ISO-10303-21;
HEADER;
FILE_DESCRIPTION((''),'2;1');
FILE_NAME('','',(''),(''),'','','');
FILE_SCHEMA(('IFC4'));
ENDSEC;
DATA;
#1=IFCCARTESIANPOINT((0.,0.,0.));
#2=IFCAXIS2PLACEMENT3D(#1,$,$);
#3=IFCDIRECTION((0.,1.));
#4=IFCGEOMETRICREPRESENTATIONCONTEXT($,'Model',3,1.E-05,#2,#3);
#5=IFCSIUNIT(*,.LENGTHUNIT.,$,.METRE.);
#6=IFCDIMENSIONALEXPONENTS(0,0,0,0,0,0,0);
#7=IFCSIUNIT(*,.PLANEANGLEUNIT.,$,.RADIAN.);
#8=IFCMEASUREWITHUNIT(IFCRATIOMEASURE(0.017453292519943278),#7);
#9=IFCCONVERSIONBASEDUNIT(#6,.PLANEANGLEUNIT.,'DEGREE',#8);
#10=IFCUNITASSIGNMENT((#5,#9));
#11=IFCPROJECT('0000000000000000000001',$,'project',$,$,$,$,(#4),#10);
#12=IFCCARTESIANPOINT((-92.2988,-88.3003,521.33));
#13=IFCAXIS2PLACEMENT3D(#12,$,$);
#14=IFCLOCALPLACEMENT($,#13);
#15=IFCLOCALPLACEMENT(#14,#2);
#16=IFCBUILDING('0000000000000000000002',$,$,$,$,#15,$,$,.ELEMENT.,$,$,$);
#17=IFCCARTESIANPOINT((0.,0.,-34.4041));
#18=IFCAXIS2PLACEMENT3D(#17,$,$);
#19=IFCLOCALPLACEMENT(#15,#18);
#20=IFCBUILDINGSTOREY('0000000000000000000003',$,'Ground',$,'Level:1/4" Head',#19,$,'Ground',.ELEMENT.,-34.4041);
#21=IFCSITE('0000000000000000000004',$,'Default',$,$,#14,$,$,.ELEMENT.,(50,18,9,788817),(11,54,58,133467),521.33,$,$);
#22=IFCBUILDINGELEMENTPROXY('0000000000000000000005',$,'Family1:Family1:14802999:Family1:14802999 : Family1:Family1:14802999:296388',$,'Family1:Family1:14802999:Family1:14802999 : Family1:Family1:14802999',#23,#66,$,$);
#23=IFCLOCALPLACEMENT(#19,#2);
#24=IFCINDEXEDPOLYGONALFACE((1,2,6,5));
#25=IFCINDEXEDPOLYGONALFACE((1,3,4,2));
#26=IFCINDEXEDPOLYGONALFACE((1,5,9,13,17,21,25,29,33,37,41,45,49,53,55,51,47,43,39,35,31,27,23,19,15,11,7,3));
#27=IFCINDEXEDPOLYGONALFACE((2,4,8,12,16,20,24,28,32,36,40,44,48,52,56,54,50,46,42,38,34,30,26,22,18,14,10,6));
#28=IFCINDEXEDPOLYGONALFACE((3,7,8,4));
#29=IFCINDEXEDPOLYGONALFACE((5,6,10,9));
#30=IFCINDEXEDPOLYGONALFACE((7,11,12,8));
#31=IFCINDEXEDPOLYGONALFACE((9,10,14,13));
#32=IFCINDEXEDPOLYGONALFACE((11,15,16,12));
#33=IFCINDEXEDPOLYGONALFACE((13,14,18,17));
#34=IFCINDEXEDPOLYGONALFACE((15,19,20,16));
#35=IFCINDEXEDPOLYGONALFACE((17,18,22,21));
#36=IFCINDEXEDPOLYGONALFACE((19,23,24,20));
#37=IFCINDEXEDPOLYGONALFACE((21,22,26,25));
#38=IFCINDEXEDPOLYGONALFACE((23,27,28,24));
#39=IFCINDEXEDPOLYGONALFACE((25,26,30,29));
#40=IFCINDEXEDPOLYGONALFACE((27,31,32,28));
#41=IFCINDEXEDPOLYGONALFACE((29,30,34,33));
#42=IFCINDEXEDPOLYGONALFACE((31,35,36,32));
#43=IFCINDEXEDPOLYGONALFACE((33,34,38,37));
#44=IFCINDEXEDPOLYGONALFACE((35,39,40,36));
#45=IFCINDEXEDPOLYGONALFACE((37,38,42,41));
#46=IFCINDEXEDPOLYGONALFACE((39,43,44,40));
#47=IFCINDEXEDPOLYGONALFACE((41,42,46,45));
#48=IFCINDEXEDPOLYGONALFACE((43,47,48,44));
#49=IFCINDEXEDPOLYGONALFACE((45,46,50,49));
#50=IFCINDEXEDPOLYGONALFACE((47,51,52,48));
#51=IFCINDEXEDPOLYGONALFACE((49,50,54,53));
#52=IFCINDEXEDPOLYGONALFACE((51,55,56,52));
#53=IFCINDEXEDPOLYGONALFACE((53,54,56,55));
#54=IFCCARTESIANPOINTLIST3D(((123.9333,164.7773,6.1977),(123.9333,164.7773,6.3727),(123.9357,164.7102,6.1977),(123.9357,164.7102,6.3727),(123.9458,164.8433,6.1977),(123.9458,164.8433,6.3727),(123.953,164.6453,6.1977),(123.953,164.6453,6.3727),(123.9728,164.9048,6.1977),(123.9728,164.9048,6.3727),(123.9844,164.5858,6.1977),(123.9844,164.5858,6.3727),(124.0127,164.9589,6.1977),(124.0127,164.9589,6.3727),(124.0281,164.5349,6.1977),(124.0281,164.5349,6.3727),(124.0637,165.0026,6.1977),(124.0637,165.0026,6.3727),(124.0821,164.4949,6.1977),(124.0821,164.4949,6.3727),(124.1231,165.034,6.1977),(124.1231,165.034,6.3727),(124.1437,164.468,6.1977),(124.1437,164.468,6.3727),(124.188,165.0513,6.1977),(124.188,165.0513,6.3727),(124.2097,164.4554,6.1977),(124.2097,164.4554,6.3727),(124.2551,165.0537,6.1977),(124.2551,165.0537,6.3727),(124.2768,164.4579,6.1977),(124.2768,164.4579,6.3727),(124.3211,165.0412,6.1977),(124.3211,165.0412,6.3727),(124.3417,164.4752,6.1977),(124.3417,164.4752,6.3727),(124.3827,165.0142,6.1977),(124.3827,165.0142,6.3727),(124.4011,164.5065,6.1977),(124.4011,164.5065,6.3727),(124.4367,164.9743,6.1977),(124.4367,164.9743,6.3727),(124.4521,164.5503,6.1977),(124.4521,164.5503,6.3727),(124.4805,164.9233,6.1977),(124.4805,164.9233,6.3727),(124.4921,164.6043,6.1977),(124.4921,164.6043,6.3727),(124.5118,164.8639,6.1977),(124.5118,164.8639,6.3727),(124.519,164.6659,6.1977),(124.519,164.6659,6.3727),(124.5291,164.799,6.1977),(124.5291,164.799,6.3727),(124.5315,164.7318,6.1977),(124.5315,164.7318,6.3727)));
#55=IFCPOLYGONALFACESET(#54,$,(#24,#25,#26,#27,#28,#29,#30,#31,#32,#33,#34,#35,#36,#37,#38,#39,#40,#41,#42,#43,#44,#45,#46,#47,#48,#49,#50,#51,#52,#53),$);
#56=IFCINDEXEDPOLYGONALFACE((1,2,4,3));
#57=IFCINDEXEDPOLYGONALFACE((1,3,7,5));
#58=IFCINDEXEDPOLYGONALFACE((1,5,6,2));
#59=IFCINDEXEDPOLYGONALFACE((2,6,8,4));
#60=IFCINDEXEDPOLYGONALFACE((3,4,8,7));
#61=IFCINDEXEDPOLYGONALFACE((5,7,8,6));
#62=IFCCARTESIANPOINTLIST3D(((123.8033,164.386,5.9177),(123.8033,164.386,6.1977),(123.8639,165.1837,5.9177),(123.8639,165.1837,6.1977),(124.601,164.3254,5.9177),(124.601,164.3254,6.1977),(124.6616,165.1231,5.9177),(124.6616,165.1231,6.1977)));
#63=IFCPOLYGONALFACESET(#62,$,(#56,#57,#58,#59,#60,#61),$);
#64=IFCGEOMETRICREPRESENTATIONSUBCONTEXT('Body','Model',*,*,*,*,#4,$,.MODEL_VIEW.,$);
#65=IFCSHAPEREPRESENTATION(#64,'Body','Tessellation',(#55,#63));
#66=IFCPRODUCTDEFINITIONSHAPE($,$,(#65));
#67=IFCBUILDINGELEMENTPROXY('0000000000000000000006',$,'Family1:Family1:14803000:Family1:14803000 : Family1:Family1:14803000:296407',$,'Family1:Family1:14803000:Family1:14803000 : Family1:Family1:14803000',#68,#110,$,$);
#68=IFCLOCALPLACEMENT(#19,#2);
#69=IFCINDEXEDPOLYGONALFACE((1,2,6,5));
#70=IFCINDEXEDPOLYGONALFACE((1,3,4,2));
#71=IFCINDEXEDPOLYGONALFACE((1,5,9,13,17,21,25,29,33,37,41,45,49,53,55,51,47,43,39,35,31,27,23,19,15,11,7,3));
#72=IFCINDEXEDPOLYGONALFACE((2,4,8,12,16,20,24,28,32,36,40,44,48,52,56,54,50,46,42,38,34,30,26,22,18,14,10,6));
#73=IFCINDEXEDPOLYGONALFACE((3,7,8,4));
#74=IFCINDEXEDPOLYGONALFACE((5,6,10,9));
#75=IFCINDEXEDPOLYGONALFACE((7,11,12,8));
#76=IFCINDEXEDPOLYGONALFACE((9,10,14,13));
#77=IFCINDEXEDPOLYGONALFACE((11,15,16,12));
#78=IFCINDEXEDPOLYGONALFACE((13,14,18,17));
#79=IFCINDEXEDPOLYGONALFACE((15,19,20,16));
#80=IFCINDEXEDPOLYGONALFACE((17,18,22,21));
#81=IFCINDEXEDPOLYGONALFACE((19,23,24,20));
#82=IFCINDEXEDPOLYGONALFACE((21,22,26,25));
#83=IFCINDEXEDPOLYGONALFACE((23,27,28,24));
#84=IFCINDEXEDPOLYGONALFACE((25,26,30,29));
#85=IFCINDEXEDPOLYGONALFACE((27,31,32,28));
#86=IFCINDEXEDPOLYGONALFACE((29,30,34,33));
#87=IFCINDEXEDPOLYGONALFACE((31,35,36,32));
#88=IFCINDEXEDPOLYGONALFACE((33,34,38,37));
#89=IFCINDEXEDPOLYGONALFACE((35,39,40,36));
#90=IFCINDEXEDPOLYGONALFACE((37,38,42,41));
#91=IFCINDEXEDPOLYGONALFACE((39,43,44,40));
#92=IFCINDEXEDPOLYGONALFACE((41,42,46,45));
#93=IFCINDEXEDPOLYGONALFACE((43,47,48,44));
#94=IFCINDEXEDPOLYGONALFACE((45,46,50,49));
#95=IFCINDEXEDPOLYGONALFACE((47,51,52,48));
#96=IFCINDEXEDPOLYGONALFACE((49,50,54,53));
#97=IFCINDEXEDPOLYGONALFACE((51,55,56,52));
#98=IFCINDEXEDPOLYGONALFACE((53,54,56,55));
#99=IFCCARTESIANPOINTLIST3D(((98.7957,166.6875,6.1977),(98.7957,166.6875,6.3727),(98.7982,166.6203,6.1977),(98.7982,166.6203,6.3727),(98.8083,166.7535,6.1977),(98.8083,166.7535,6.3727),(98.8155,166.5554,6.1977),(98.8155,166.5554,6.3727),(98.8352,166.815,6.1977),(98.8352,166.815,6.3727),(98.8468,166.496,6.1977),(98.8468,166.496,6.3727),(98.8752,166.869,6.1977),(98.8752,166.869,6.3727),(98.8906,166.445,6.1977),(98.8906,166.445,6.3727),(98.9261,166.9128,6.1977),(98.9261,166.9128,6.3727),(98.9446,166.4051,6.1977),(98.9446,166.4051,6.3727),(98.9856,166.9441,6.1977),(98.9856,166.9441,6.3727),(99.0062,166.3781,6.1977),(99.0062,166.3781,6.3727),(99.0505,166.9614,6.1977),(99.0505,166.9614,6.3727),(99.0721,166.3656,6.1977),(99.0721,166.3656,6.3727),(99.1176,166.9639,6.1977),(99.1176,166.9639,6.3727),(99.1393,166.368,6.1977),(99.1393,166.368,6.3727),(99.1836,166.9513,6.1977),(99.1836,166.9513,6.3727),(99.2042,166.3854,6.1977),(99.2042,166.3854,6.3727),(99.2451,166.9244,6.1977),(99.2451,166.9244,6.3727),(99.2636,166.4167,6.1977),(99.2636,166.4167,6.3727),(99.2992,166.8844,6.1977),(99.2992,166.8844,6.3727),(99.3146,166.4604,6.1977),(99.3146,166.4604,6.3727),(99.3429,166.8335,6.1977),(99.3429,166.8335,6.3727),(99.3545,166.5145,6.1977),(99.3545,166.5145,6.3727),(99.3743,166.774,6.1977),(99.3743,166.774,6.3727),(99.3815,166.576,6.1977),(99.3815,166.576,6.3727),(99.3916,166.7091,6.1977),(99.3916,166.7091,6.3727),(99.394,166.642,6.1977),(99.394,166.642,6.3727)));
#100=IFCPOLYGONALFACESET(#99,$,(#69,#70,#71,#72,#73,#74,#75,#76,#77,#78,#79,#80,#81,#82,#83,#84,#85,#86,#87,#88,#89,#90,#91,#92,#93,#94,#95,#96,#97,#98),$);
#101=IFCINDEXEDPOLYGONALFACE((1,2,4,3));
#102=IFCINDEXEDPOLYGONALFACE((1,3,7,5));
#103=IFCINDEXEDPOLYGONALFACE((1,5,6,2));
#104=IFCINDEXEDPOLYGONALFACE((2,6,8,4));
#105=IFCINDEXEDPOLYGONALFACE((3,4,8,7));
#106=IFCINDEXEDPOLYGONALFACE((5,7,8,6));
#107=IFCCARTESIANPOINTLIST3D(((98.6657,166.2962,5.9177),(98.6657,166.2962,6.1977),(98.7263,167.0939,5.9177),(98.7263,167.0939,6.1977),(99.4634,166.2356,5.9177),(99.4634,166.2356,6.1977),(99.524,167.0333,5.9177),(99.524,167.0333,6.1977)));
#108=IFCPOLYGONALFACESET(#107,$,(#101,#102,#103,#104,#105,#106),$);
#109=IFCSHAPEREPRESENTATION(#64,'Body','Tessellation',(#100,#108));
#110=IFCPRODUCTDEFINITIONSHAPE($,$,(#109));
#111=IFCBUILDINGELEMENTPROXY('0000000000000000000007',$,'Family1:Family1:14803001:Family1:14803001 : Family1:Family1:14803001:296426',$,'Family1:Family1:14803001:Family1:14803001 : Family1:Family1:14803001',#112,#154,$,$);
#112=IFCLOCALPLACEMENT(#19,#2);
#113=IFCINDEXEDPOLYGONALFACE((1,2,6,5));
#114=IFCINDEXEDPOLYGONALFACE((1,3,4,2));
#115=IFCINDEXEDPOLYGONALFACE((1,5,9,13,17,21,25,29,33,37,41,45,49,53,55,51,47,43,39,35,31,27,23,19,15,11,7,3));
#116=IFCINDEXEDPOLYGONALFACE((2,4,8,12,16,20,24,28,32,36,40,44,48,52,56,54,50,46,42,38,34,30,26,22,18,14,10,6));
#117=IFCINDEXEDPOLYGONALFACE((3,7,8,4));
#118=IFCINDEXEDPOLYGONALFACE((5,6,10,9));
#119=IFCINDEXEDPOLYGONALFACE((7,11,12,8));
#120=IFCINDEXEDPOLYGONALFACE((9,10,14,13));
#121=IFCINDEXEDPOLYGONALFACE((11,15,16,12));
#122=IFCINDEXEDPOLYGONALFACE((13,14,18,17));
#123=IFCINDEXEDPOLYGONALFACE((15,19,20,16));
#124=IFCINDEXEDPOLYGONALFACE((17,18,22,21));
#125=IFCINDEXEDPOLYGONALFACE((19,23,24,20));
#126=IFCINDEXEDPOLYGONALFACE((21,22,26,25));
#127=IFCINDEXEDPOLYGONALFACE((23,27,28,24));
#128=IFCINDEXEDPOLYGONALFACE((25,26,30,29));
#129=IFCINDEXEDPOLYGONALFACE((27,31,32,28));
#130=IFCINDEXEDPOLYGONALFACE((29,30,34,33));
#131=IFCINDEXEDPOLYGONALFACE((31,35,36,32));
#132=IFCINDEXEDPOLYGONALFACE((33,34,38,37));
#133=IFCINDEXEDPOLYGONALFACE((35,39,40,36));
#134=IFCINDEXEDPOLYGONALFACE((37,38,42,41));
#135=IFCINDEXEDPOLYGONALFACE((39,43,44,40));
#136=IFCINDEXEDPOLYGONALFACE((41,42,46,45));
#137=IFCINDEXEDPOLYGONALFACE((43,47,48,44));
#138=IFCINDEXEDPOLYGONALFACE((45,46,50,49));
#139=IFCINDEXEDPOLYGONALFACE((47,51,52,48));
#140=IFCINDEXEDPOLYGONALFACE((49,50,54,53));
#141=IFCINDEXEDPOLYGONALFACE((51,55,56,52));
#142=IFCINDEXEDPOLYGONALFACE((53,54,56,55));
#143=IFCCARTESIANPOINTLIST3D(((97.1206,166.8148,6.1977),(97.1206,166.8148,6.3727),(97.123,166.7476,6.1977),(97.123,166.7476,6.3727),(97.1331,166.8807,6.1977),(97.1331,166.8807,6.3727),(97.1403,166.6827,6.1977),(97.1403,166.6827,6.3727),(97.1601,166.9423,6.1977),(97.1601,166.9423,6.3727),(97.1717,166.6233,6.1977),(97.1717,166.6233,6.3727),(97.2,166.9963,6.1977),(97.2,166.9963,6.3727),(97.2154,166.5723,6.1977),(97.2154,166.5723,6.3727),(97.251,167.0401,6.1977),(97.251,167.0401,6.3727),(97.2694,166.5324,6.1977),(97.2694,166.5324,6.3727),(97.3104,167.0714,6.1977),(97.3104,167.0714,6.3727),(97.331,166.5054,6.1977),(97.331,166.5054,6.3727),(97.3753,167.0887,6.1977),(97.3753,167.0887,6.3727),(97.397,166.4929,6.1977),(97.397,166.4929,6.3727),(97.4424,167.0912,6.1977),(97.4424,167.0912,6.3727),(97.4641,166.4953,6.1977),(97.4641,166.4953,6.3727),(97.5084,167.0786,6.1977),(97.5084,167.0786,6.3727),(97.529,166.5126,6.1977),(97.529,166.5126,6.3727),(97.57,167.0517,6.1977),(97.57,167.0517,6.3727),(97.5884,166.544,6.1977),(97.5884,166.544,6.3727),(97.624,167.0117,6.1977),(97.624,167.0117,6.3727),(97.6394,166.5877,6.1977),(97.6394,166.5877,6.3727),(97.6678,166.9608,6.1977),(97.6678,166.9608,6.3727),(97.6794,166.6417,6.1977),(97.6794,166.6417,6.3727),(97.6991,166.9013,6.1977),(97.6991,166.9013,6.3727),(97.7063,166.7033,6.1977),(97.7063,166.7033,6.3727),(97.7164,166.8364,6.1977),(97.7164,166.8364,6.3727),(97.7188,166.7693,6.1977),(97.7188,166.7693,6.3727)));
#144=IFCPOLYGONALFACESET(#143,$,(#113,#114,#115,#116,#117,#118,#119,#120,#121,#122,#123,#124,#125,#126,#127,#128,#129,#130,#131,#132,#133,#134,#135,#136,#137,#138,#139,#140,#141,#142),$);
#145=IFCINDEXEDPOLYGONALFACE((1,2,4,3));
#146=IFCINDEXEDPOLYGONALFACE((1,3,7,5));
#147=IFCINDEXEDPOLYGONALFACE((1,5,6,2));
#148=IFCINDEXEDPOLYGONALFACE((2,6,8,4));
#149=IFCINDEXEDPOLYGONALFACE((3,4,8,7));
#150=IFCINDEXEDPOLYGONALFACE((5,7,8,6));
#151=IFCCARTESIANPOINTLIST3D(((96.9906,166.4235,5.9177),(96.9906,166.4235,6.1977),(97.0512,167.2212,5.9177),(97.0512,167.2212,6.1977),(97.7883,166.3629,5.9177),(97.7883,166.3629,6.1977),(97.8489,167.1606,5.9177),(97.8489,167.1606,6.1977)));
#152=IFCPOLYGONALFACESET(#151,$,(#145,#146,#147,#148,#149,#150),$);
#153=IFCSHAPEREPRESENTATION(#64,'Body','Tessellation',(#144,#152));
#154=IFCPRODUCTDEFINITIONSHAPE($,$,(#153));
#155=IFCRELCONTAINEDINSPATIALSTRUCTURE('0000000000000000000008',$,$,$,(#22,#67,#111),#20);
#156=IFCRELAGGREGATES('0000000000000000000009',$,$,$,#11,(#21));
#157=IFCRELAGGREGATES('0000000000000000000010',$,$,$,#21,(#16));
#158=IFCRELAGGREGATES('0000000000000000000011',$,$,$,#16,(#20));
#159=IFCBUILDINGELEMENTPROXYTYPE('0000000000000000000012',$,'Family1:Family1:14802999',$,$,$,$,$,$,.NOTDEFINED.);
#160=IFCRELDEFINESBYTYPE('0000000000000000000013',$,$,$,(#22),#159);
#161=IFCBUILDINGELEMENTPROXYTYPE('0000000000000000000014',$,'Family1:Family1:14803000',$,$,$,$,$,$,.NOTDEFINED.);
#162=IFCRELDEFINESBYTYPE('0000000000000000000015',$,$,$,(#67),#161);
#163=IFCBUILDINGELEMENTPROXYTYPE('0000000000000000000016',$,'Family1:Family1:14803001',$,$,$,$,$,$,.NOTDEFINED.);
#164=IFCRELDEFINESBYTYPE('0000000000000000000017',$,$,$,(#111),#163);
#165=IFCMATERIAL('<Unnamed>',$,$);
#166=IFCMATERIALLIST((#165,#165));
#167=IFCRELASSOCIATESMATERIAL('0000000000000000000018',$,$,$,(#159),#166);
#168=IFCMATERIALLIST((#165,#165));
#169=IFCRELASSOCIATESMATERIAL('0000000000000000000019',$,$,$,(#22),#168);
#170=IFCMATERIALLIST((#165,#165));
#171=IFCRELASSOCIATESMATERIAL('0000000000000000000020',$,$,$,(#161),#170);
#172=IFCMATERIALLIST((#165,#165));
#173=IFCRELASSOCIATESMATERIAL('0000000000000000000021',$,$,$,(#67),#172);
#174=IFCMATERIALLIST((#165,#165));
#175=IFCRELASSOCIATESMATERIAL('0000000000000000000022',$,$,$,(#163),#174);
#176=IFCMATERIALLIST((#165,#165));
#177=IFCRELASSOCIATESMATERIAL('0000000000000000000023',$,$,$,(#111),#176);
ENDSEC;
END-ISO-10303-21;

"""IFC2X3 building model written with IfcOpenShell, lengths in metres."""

from ifc_helpers import new_model, entity, si_unit, converted_unit, direction, frame, frame_2d, origin, origin_2d_with_axis, place, context, subcontext, project, spatial, rectangle, circle, extrude, source, transform, mapped, material, material_list, type_object, type_shapes, element, save


model = new_model("IFC2X3")

# Units and contexts
model_context = context("Model", 3, precision=1e-05, world=origin(), true_north=direction((0.0, 1.0)))
body_context = subcontext(model_context, "Body", "Model", "MODEL_VIEW")
ifc_project = project(units=[si_unit("LENGTHUNIT", "METRE"), converted_unit("PLANEANGLEUNIT", "DEGREE", entity("IfcRatioMeasure", 0.017453292519943278), si_unit("PLANEANGLEUNIT", "RADIAN"), dimensions=[0, 0, 0, 0, 0, 0, 0])], contexts=[model_context])

# Site, building, storey
site_placement = place(None, frame((-92.2988, -88.3003, 521.33)))
site = spatial("IfcSite", under=ifc_project, at=site_placement, Name="Default", CompositionType="ELEMENT", RefLatitude=(50, 18, 9, 788817), RefLongitude=(11, 54, 58, 133467), RefElevation=521.33)
building_placement = place(site_placement, origin())
building = spatial("IfcBuilding", under=site, at=building_placement, CompositionType="ELEMENT")
storey_placement = place(building_placement, frame((0.0, 0.0, -34.4041)))
storey = spatial("IfcBuildingStorey", under=building, at=storey_placement, Name="Ground", ObjectType="Level:1/4\" Head", LongName="Ground", CompositionType="ELEMENT", Elevation=-34.4041)

# Building element proxies
ifc_material_1 = material(Name="<Unnamed>")
ifc_material_list_1 = material_list([ifc_material_1, ifc_material_1])
ifc_material_list_2 = material_list([ifc_material_1, ifc_material_1])
building_element_proxy_type_1 = type_object("IfcBuildingElementProxyType", Name="Family1:Family1:14802999", PredefinedType="NOTDEFINED", material=ifc_material_list_2)
shared_shape_1 = source(origin(), body_context, "Body", "SweptSolid", [
    extrude(circle(Radius=0.3, at=frame_2d((0.0, 0.0), x_axis=(1.0, 0.0))), frame((124.2324, 164.7546, -28.2064), z_axis=(0.0, 0.0, 1.0), x_axis=(0.997125, -0.07577, 0.0)), (0.0, 0.0, 1.0), 0.175),
    extrude(rectangle(XDim=0.8, YDim=0.8, at=frame_2d((0.0, 0.0), x_axis=(1.0, 0.0))), frame((124.2324, 164.7546, -28.4864), z_axis=(0.0, 0.0, 1.0), x_axis=(-0.07577, -0.997125, 0.0)), (0.0, 0.0, 1.0), 0.28),
])
type_shapes(building_element_proxy_type_1, [shared_shape_1])
proxy_1_placement = place(storey_placement, frame((0.0, 0.0, 34.4041)))
element("IfcBuildingElementProxy", 1, at=proxy_1_placement, inside=storey, type_object=building_element_proxy_type_1, material=ifc_material_list_1, Name="Family1:Family1:14802999:Family1:14802999 : Family1:Family1:14802999:296388", ObjectType="Family1:Family1:14802999:Family1:14802999 : Family1:Family1:14802999", context=body_context, shape_type="MappedRepresentation", body=[
    mapped(shared_shape_1, transform((0.0, 0.0, 0.0), scale=1.0)),
])
ifc_material_list_3 = material_list([ifc_material_1, ifc_material_1])
ifc_material_list_4 = material_list([ifc_material_1, ifc_material_1])
building_element_proxy_type_2 = type_object("IfcBuildingElementProxyType", Name="Family1:Family1:14803000", PredefinedType="NOTDEFINED", material=ifc_material_list_4)
shared_shape_2 = source(origin(), body_context, "Body", "SweptSolid", [
    extrude(circle(Radius=0.3, at=origin_2d_with_axis()), frame((99.0949, 166.6647, -28.2064), z_axis=(0.0, 0.0, 1.0), x_axis=(0.997125, -0.07577, 0.0)), (0.0, 0.0, 1.0), 0.175),
    extrude(rectangle(XDim=0.8, YDim=0.8, at=frame_2d((0.0, 0.0), x_axis=(1.0, 0.0))), frame((99.0949, 166.6647, -28.4864), z_axis=(0.0, 0.0, 1.0), x_axis=(-0.07577, -0.997125, 0.0)), (0.0, 0.0, 1.0), 0.28),
])
type_shapes(building_element_proxy_type_2, [shared_shape_2])
proxy_2_placement = place(storey_placement, frame((0.0, 0.0, 34.4041)))
element("IfcBuildingElementProxy", 2, at=proxy_2_placement, inside=storey, type_object=building_element_proxy_type_2, material=ifc_material_list_3, Name="Family1:Family1:14803000:Family1:14803000 : Family1:Family1:14803000:296407", ObjectType="Family1:Family1:14803000:Family1:14803000 : Family1:Family1:14803000", context=body_context, shape_type="MappedRepresentation", body=[
    mapped(shared_shape_2, transform((0.0, 0.0, 0.0), scale=1.0)),
])
ifc_material_list_5 = material_list([ifc_material_1, ifc_material_1])
ifc_material_list_6 = material_list([ifc_material_1, ifc_material_1])
building_element_proxy_type_3 = type_object("IfcBuildingElementProxyType", Name="Family1:Family1:14803001", PredefinedType="NOTDEFINED", material=ifc_material_list_6)
shared_shape_3 = source(origin(), body_context, "Body", "SweptSolid", [
    extrude(circle(Radius=0.3, at=frame_2d((0.0, 0.0), x_axis=(1.0, 0.0))), frame((97.4197, 166.792, -28.2064), z_axis=(0.0, 0.0, 1.0), x_axis=(0.997125, -0.07577, 0.0)), (0.0, 0.0, 1.0), 0.175),
    extrude(rectangle(XDim=0.8, YDim=0.8, at=frame_2d((0.0, 0.0), x_axis=(1.0, 0.0))), frame((97.4197, 166.792, -28.4864), z_axis=(0.0, 0.0, 1.0), x_axis=(-0.07577, -0.997125, 0.0)), (0.0, 0.0, 1.0), 0.28),
])
type_shapes(building_element_proxy_type_3, [shared_shape_3])
proxy_3_placement = place(storey_placement, frame((0.0, 0.0, 34.4041)))
element("IfcBuildingElementProxy", 3, at=proxy_3_placement, inside=storey, type_object=building_element_proxy_type_3, material=ifc_material_list_5, Name="Family1:Family1:14803001:Family1:14803001 : Family1:Family1:14803001:296426", ObjectType="Family1:Family1:14803001:Family1:14803001 : Family1:Family1:14803001", context=body_context, shape_type="MappedRepresentation", body=[
    mapped(shared_shape_3, transform((0.0, 0.0, 0.0), scale=1.0)),
])

save(model, "model.ifc")
